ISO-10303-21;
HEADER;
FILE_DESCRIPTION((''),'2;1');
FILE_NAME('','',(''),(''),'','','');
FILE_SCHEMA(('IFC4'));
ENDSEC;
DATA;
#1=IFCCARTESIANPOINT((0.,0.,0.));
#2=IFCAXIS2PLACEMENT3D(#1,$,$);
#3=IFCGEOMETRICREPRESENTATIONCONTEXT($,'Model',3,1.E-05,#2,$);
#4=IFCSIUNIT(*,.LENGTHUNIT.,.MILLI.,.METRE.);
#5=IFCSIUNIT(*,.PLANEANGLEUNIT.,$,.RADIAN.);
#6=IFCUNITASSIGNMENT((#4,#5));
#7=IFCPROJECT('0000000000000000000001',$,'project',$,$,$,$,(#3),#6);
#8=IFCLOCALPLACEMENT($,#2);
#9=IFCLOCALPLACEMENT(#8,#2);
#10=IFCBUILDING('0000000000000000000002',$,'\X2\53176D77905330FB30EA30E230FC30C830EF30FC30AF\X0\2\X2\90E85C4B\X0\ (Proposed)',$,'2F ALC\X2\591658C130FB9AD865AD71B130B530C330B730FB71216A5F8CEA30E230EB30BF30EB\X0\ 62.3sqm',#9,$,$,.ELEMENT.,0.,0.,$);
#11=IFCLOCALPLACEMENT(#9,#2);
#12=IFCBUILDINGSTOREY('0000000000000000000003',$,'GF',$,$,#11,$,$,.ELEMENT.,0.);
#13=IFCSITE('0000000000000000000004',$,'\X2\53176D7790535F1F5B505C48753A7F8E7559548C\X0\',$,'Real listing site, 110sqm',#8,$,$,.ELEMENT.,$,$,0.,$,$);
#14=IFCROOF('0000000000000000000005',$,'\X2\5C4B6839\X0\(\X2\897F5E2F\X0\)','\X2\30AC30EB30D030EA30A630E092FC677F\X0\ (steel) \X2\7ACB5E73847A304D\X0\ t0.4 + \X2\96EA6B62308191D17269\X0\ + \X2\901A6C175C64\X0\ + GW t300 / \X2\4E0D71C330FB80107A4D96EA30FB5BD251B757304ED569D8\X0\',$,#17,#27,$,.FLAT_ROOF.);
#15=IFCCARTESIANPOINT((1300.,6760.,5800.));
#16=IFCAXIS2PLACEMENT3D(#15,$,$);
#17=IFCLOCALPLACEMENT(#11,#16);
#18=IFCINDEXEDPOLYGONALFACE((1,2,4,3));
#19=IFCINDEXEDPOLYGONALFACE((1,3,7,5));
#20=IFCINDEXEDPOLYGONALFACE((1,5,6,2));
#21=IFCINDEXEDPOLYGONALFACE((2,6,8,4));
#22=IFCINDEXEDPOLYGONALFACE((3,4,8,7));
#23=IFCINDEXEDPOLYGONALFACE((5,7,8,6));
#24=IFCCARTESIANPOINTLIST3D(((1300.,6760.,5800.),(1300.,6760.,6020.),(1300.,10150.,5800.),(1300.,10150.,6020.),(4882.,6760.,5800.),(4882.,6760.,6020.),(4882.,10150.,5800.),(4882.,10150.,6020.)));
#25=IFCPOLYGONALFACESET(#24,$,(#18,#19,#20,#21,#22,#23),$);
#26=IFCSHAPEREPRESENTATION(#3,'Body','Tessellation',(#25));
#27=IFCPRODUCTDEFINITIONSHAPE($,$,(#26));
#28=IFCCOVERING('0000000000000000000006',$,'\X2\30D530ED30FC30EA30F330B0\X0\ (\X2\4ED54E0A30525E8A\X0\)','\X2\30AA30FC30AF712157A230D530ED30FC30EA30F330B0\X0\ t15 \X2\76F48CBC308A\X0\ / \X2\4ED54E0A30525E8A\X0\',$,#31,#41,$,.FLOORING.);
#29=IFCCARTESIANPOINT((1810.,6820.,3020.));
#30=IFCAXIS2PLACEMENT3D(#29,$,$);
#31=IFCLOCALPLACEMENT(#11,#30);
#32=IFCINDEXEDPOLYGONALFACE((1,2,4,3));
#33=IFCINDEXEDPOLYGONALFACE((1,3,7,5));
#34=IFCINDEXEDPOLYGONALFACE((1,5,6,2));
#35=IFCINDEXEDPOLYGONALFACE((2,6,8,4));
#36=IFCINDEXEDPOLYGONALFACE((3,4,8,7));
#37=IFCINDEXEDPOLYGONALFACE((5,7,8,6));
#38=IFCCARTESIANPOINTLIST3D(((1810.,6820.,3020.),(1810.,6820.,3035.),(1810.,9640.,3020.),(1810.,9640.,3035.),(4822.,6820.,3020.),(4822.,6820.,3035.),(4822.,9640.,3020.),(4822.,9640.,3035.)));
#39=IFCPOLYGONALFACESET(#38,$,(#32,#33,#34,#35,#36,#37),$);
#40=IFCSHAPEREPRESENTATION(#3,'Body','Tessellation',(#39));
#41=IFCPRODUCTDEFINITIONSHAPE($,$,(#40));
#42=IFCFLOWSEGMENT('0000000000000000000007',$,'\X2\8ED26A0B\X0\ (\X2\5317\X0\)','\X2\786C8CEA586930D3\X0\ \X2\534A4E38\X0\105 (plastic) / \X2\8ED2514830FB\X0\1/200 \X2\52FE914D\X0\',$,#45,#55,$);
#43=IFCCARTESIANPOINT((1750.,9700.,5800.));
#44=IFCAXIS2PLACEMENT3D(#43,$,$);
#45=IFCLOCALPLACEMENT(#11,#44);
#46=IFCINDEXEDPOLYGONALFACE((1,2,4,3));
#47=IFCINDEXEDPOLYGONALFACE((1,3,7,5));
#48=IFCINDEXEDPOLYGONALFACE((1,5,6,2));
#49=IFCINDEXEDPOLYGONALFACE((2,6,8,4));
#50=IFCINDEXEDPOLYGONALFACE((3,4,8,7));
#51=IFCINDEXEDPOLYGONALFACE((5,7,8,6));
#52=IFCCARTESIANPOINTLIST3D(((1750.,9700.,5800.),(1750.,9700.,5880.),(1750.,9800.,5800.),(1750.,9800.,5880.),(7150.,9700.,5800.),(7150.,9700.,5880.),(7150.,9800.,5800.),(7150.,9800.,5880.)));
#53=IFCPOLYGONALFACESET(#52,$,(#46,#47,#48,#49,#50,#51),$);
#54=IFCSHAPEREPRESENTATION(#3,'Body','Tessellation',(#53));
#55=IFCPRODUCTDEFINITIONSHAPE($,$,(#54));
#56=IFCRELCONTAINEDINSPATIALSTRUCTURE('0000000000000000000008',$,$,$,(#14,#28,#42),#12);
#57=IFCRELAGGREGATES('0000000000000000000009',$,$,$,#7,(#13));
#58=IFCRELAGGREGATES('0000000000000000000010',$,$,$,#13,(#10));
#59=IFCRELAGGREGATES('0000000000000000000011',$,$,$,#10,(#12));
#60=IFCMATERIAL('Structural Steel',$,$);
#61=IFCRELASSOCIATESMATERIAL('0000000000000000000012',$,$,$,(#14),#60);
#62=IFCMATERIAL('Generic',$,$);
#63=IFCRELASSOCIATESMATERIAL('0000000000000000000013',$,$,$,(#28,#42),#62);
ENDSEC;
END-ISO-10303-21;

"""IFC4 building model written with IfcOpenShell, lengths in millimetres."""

from ifc_helpers import new_model, si_unit, frame, frame_2d, origin, place, context, project, spatial, rectangle, extrude, material, element, save


model = new_model("IFC4")

# Units and contexts
model_context = context("Model", 3, precision=1e-05, world=origin())
ifc_project = project(units=[si_unit("LENGTHUNIT", "METRE", prefix="MILLI"), si_unit("PLANEANGLEUNIT", "RADIAN")], contexts=[model_context])

# Site, building, storey
site_placement = place(None, origin())
site = spatial("IfcSite", under=ifc_project, at=site_placement, Name="北海道弟子屈町美留和", ObjectType="Real listing site, 110sqm", CompositionType="ELEMENT", RefElevation=0.0)
building_placement = place(site_placement, origin())
building = spatial("IfcBuilding", under=site, at=building_placement, Name="北海道・リモートワーク2部屋 (Proposed)", ObjectType="2F ALC外壁・高断熱サッシ・無機質モルタル 62.3sqm", CompositionType="ELEMENT", ElevationOfRefHeight=0.0, ElevationOfTerrain=0.0)
storey_placement = place(building_placement, origin())
storey = spatial("IfcBuildingStorey", under=building, at=storey_placement, Name="GF", CompositionType="ELEMENT", Elevation=0.0)

# Roof
ifc_material_1 = material(Name="Structural Steel")
for number, where, name in (
    (1, (1300.0, 6760.0, 5800.0), "屋根(西帯)"),
):
    element("IfcRoof", number, at=place(storey_placement, frame(where)), inside=storey, material=ifc_material_1, Name=name, Description="ガルバリウム鋼板 (steel) 立平葺き t0.4 + 雪止め金物 + 通気層 + GW t300 / 不燃・耐積雪・寒冷地仕様", PredefinedType="FLAT_ROOF", context=model_context, shape_type="SweptSolid", body=[
        extrude(rectangle(XDim=3582.0, YDim=3390.0, at=frame_2d((1791.0, 1695.0))), frame((1300.0, 6760.0, 5800.0)), (0.0, 0.0, 1.0), 220.0),
    ])

# Covering
ifc_material_2 = material(Name="Generic")
covering_placement = place(storey_placement, frame((1810.0, 6820.0, 3020.0)))
element("IfcCovering", 2, at=covering_placement, inside=storey, material=ifc_material_2, Name="フローリング (仕上げ床)", Description="オーク無垢フローリング t15 直貼り / 仕上げ床", PredefinedType="FLOORING", context=model_context, shape_type="SweptSolid", body=[
    extrude(rectangle(XDim=3012.0, YDim=2820.0, at=frame_2d((1506.0, 1410.0))), frame((1810.0, 6820.0, 3020.0)), (0.0, 0.0, 1.0), 15.0),
])

# Flow segment
flow_segment_placement = place(storey_placement, frame((1750.0, 9700.0, 5800.0)))
element("IfcFlowSegment", 3, at=flow_segment_placement, inside=storey, material=ifc_material_2, Name="軒樋 (北)", Description="硬質塩ビ 半丸105 (plastic) / 軒先・1/200 勾配", context=model_context, shape_type="SweptSolid", body=[
    extrude(rectangle(XDim=5400.0, YDim=100.0, at=frame_2d((2700.0, 50.0))), frame((1750.0, 9700.0, 5800.0)), (0.0, 0.0, 1.0), 80.0),
])

save(model, "model.ifc")
